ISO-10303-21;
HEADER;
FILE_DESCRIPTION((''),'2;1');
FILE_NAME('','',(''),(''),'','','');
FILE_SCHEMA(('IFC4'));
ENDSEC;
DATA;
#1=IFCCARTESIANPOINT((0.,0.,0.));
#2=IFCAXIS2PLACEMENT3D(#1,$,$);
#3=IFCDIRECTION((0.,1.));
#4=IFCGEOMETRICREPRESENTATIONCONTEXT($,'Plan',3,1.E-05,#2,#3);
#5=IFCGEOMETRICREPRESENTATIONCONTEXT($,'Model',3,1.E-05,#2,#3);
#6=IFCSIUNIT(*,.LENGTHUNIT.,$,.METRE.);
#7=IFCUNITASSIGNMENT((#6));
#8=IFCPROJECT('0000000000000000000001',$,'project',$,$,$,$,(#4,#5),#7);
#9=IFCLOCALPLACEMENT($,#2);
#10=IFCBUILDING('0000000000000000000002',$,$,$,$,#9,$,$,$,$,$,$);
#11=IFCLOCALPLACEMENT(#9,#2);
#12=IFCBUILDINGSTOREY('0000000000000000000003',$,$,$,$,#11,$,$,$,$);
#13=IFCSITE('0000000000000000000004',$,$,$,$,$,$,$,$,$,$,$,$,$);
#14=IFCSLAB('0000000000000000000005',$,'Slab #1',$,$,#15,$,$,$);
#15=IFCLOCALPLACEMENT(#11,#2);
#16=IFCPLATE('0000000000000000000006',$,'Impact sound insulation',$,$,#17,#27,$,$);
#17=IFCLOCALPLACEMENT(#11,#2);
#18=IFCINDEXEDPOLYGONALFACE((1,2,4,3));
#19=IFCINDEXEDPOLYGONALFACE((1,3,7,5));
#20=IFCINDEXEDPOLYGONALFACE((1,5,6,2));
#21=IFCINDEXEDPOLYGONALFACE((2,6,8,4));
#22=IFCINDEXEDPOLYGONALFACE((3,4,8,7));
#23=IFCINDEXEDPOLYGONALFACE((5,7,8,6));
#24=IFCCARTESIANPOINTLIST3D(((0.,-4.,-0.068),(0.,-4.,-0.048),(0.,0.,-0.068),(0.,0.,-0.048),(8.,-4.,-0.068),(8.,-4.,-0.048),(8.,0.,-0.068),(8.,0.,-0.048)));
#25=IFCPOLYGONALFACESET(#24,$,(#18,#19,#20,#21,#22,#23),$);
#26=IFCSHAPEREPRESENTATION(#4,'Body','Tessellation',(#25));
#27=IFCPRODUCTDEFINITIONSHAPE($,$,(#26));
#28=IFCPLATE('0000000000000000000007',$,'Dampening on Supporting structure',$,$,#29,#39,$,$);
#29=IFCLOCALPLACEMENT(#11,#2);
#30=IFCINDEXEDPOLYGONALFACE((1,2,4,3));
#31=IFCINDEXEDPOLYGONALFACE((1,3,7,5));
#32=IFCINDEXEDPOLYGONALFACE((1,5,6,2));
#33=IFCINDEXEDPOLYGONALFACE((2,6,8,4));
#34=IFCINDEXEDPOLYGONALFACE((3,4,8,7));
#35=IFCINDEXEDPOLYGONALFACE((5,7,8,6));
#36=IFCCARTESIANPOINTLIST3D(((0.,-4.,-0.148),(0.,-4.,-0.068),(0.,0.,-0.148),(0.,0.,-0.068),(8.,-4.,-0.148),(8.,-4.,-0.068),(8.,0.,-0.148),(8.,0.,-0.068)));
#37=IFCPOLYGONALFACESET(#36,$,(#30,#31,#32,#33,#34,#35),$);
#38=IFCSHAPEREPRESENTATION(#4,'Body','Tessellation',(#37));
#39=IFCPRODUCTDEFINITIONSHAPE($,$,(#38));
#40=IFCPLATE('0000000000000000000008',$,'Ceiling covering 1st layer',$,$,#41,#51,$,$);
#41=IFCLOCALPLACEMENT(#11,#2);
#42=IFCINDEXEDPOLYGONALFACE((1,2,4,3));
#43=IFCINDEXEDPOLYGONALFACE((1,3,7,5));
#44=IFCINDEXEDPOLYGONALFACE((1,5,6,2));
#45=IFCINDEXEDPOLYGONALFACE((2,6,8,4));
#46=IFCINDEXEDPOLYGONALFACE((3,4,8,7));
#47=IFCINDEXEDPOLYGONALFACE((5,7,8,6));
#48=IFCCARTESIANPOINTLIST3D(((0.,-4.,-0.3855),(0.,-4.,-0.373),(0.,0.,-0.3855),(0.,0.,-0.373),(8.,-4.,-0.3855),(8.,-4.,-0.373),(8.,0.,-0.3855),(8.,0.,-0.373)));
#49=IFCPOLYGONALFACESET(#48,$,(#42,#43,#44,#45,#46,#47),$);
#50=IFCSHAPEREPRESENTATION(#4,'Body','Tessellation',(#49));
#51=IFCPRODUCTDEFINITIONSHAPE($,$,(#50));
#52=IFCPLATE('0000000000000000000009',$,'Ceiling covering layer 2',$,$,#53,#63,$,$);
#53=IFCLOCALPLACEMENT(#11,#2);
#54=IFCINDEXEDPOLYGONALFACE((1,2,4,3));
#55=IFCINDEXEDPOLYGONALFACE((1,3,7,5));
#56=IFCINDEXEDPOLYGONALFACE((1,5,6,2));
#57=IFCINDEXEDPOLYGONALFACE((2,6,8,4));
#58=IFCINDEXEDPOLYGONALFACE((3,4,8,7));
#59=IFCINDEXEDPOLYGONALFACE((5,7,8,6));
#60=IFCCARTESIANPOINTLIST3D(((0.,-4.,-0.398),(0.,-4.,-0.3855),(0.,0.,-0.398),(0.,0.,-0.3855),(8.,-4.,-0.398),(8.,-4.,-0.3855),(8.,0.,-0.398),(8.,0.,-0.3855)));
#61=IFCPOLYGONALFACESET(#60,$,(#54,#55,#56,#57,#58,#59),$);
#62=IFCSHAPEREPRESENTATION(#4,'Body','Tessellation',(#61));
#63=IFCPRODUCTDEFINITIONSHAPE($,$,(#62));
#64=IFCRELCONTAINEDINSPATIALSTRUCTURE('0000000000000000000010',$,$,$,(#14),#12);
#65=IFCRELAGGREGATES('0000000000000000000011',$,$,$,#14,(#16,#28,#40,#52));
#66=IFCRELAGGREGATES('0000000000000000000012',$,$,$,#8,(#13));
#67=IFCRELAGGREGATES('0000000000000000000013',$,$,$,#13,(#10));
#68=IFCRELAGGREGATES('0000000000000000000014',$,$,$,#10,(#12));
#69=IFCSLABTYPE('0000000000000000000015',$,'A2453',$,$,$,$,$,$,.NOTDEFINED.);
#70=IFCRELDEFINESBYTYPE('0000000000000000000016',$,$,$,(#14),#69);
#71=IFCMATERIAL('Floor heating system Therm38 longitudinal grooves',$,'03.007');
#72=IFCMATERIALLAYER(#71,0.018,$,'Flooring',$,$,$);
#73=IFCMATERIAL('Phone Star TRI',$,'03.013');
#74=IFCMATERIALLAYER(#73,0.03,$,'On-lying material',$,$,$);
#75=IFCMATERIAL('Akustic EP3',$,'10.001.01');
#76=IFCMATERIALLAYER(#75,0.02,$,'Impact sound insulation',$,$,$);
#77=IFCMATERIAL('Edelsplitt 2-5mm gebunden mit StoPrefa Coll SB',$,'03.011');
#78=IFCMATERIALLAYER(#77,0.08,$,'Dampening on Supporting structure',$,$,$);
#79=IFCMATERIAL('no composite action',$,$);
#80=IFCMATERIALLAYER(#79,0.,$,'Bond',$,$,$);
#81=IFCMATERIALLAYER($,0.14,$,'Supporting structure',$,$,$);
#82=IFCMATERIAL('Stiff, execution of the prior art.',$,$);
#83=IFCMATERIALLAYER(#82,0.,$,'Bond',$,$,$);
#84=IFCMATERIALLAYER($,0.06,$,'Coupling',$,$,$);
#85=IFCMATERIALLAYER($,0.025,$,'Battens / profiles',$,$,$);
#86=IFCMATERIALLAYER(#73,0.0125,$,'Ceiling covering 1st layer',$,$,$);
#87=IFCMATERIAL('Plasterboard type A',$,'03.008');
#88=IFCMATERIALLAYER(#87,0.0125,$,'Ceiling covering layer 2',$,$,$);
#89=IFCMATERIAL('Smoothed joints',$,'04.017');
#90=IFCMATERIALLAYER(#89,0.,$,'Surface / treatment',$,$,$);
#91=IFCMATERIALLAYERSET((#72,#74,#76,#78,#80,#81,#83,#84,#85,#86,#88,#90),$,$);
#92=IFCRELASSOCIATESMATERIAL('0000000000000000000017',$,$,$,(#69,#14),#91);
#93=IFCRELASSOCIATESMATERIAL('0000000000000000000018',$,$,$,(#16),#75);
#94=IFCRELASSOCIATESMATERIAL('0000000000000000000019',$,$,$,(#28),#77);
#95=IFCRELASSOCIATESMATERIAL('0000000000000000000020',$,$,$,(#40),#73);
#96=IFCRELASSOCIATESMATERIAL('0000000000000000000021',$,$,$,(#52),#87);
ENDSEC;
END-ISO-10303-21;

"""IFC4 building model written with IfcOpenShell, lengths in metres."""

from ifc_helpers import new_model, si_unit, direction, frame, frame_2d, origin, place, context, project, spatial, rectangle, extrude, material, layer, layer_set, type_object, element, aggregate, save


model = new_model("IFC4")

# Units and contexts
plan_context = context("Plan", 3, precision=1e-05, world=origin(), true_north=direction((0.0, 1.0)))
model_context = context("Model", 3, precision=1e-05, world=origin(), true_north=direction((0.0, 1.0)))
ifc_project = project(units=[si_unit("LENGTHUNIT", "METRE")], contexts=[plan_context, model_context])

# Site, building, storey
site = spatial("IfcSite", under=ifc_project)
building_placement = place(None, origin())
building = spatial("IfcBuilding", under=site, at=building_placement)
storey_placement = place(building_placement, origin())
storey = spatial("IfcBuildingStorey", under=building, at=storey_placement)

# Slab, plates
ifc_material_1 = material(Name="Floor heating system Therm38 longitudinal grooves", Category="03.007")
ifc_layer_1 = layer(ifc_material_1, 0.018, Name="Flooring")
ifc_material_2 = material(Name="Phone Star TRI", Category="03.013")
ifc_layer_2 = layer(ifc_material_2, 0.03, Name="On-lying material")
ifc_material_3 = material(Name="Akustic EP3", Category="10.001.01")
ifc_layer_3 = layer(ifc_material_3, 0.02, Name="Impact sound insulation")
ifc_material_4 = material(Name="Edelsplitt 2-5mm gebunden mit StoPrefa Coll SB", Category="03.011")
ifc_layer_4 = layer(ifc_material_4, 0.08, Name="Dampening on Supporting structure")
ifc_material_5 = material(Name="no composite action")
ifc_layer_5 = layer(ifc_material_5, 0.0, Name="Bond")
ifc_layer_6 = layer(None, 0.14, Name="Supporting structure")
ifc_material_6 = material(Name="Stiff, execution of the prior art.")
ifc_layer_7 = layer(ifc_material_6, 0.0, Name="Bond")
ifc_layer_8 = layer(None, 0.06, Name="Coupling")
ifc_layer_9 = layer(None, 0.025, Name="Battens / profiles")
ifc_layer_10 = layer(ifc_material_2, 0.0125, Name="Ceiling covering 1st layer")
ifc_material_7 = material(Name="Plasterboard type A", Category="03.008")
ifc_layer_11 = layer(ifc_material_7, 0.0125, Name="Ceiling covering layer 2")
ifc_material_8 = material(Name="Smoothed joints", Category="04.017")
ifc_layer_12 = layer(ifc_material_8, 0.0, Name="Surface / treatment")
ifc_layer_set = layer_set([ifc_layer_1, ifc_layer_2, ifc_layer_3, ifc_layer_4, ifc_layer_5, ifc_layer_6, ifc_layer_7, ifc_layer_8, ifc_layer_9, ifc_layer_10, ifc_layer_11, ifc_layer_12])
slab_type = type_object("IfcSlabType", Name="A2453", PredefinedType="NOTDEFINED", material=ifc_layer_set)
slab_placement = place(None, frame((0.0, 0.0, 0.0), z_axis=(0.0, 0.0, -1.0), x_axis=(1.0, 0.0, 0.0)))
slab = element("IfcSlab", 1, at=slab_placement, inside=storey, type_object=slab_type, material=ifc_layer_set, Name="Slab #1")
plate_1_placement = place(slab_placement, origin())
plate_1 = element("IfcPlate", 2, at=plate_1_placement, material=ifc_material_3, Name="Impact sound insulation", context=plan_context, shape_type="SweptSolid", body=[
    extrude(rectangle(XDim=8.0, YDim=4.0, at=frame_2d((4.0, 2.0), x_axis=(1.0, 0.0))), frame((0.0, 0.0, 0.048), z_axis=(0.0, 0.0, 1.0), x_axis=(1.0, 0.0, 0.0)), (0.0, 0.0, 1.0), 0.02),
])
plate_2_placement = place(slab_placement, origin())
plate_2 = element("IfcPlate", 3, at=plate_2_placement, material=ifc_material_4, Name="Dampening on Supporting structure", context=plan_context, shape_type="SweptSolid", body=[
    extrude(rectangle(XDim=8.0, YDim=4.0, at=frame_2d((4.0, 2.0), x_axis=(1.0, 0.0))), frame((0.0, 0.0, 0.068), z_axis=(0.0, 0.0, 1.0), x_axis=(1.0, 0.0, 0.0)), (0.0, 0.0, 1.0), 0.08),
])
plate_3_placement = place(slab_placement, origin())
plate_3 = element("IfcPlate", 4, at=plate_3_placement, material=ifc_material_2, Name="Ceiling covering 1st layer", context=plan_context, shape_type="SweptSolid", body=[
    extrude(rectangle(XDim=8.0, YDim=4.0, at=frame_2d((4.0, 2.0), x_axis=(1.0, 0.0))), frame((0.0, 0.0, 0.373), z_axis=(0.0, 0.0, 1.0), x_axis=(1.0, 0.0, 0.0)), (0.0, 0.0, 1.0), 0.0125),
])
plate_4_placement = place(slab_placement, origin())
plate_4 = element("IfcPlate", 5, at=plate_4_placement, material=ifc_material_7, Name="Ceiling covering layer 2", context=plan_context, shape_type="SweptSolid", body=[
    extrude(rectangle(XDim=8.0, YDim=4.0, at=frame_2d((4.0, 2.0), x_axis=(1.0, 0.0))), frame((0.0, 0.0, 0.3855), z_axis=(0.0, 0.0, 1.0), x_axis=(1.0, 0.0, 0.0)), (0.0, 0.0, 1.0), 0.0125),
])
aggregate(slab, [plate_1, plate_2, plate_3, plate_4])

save(model, "model.ifc")
